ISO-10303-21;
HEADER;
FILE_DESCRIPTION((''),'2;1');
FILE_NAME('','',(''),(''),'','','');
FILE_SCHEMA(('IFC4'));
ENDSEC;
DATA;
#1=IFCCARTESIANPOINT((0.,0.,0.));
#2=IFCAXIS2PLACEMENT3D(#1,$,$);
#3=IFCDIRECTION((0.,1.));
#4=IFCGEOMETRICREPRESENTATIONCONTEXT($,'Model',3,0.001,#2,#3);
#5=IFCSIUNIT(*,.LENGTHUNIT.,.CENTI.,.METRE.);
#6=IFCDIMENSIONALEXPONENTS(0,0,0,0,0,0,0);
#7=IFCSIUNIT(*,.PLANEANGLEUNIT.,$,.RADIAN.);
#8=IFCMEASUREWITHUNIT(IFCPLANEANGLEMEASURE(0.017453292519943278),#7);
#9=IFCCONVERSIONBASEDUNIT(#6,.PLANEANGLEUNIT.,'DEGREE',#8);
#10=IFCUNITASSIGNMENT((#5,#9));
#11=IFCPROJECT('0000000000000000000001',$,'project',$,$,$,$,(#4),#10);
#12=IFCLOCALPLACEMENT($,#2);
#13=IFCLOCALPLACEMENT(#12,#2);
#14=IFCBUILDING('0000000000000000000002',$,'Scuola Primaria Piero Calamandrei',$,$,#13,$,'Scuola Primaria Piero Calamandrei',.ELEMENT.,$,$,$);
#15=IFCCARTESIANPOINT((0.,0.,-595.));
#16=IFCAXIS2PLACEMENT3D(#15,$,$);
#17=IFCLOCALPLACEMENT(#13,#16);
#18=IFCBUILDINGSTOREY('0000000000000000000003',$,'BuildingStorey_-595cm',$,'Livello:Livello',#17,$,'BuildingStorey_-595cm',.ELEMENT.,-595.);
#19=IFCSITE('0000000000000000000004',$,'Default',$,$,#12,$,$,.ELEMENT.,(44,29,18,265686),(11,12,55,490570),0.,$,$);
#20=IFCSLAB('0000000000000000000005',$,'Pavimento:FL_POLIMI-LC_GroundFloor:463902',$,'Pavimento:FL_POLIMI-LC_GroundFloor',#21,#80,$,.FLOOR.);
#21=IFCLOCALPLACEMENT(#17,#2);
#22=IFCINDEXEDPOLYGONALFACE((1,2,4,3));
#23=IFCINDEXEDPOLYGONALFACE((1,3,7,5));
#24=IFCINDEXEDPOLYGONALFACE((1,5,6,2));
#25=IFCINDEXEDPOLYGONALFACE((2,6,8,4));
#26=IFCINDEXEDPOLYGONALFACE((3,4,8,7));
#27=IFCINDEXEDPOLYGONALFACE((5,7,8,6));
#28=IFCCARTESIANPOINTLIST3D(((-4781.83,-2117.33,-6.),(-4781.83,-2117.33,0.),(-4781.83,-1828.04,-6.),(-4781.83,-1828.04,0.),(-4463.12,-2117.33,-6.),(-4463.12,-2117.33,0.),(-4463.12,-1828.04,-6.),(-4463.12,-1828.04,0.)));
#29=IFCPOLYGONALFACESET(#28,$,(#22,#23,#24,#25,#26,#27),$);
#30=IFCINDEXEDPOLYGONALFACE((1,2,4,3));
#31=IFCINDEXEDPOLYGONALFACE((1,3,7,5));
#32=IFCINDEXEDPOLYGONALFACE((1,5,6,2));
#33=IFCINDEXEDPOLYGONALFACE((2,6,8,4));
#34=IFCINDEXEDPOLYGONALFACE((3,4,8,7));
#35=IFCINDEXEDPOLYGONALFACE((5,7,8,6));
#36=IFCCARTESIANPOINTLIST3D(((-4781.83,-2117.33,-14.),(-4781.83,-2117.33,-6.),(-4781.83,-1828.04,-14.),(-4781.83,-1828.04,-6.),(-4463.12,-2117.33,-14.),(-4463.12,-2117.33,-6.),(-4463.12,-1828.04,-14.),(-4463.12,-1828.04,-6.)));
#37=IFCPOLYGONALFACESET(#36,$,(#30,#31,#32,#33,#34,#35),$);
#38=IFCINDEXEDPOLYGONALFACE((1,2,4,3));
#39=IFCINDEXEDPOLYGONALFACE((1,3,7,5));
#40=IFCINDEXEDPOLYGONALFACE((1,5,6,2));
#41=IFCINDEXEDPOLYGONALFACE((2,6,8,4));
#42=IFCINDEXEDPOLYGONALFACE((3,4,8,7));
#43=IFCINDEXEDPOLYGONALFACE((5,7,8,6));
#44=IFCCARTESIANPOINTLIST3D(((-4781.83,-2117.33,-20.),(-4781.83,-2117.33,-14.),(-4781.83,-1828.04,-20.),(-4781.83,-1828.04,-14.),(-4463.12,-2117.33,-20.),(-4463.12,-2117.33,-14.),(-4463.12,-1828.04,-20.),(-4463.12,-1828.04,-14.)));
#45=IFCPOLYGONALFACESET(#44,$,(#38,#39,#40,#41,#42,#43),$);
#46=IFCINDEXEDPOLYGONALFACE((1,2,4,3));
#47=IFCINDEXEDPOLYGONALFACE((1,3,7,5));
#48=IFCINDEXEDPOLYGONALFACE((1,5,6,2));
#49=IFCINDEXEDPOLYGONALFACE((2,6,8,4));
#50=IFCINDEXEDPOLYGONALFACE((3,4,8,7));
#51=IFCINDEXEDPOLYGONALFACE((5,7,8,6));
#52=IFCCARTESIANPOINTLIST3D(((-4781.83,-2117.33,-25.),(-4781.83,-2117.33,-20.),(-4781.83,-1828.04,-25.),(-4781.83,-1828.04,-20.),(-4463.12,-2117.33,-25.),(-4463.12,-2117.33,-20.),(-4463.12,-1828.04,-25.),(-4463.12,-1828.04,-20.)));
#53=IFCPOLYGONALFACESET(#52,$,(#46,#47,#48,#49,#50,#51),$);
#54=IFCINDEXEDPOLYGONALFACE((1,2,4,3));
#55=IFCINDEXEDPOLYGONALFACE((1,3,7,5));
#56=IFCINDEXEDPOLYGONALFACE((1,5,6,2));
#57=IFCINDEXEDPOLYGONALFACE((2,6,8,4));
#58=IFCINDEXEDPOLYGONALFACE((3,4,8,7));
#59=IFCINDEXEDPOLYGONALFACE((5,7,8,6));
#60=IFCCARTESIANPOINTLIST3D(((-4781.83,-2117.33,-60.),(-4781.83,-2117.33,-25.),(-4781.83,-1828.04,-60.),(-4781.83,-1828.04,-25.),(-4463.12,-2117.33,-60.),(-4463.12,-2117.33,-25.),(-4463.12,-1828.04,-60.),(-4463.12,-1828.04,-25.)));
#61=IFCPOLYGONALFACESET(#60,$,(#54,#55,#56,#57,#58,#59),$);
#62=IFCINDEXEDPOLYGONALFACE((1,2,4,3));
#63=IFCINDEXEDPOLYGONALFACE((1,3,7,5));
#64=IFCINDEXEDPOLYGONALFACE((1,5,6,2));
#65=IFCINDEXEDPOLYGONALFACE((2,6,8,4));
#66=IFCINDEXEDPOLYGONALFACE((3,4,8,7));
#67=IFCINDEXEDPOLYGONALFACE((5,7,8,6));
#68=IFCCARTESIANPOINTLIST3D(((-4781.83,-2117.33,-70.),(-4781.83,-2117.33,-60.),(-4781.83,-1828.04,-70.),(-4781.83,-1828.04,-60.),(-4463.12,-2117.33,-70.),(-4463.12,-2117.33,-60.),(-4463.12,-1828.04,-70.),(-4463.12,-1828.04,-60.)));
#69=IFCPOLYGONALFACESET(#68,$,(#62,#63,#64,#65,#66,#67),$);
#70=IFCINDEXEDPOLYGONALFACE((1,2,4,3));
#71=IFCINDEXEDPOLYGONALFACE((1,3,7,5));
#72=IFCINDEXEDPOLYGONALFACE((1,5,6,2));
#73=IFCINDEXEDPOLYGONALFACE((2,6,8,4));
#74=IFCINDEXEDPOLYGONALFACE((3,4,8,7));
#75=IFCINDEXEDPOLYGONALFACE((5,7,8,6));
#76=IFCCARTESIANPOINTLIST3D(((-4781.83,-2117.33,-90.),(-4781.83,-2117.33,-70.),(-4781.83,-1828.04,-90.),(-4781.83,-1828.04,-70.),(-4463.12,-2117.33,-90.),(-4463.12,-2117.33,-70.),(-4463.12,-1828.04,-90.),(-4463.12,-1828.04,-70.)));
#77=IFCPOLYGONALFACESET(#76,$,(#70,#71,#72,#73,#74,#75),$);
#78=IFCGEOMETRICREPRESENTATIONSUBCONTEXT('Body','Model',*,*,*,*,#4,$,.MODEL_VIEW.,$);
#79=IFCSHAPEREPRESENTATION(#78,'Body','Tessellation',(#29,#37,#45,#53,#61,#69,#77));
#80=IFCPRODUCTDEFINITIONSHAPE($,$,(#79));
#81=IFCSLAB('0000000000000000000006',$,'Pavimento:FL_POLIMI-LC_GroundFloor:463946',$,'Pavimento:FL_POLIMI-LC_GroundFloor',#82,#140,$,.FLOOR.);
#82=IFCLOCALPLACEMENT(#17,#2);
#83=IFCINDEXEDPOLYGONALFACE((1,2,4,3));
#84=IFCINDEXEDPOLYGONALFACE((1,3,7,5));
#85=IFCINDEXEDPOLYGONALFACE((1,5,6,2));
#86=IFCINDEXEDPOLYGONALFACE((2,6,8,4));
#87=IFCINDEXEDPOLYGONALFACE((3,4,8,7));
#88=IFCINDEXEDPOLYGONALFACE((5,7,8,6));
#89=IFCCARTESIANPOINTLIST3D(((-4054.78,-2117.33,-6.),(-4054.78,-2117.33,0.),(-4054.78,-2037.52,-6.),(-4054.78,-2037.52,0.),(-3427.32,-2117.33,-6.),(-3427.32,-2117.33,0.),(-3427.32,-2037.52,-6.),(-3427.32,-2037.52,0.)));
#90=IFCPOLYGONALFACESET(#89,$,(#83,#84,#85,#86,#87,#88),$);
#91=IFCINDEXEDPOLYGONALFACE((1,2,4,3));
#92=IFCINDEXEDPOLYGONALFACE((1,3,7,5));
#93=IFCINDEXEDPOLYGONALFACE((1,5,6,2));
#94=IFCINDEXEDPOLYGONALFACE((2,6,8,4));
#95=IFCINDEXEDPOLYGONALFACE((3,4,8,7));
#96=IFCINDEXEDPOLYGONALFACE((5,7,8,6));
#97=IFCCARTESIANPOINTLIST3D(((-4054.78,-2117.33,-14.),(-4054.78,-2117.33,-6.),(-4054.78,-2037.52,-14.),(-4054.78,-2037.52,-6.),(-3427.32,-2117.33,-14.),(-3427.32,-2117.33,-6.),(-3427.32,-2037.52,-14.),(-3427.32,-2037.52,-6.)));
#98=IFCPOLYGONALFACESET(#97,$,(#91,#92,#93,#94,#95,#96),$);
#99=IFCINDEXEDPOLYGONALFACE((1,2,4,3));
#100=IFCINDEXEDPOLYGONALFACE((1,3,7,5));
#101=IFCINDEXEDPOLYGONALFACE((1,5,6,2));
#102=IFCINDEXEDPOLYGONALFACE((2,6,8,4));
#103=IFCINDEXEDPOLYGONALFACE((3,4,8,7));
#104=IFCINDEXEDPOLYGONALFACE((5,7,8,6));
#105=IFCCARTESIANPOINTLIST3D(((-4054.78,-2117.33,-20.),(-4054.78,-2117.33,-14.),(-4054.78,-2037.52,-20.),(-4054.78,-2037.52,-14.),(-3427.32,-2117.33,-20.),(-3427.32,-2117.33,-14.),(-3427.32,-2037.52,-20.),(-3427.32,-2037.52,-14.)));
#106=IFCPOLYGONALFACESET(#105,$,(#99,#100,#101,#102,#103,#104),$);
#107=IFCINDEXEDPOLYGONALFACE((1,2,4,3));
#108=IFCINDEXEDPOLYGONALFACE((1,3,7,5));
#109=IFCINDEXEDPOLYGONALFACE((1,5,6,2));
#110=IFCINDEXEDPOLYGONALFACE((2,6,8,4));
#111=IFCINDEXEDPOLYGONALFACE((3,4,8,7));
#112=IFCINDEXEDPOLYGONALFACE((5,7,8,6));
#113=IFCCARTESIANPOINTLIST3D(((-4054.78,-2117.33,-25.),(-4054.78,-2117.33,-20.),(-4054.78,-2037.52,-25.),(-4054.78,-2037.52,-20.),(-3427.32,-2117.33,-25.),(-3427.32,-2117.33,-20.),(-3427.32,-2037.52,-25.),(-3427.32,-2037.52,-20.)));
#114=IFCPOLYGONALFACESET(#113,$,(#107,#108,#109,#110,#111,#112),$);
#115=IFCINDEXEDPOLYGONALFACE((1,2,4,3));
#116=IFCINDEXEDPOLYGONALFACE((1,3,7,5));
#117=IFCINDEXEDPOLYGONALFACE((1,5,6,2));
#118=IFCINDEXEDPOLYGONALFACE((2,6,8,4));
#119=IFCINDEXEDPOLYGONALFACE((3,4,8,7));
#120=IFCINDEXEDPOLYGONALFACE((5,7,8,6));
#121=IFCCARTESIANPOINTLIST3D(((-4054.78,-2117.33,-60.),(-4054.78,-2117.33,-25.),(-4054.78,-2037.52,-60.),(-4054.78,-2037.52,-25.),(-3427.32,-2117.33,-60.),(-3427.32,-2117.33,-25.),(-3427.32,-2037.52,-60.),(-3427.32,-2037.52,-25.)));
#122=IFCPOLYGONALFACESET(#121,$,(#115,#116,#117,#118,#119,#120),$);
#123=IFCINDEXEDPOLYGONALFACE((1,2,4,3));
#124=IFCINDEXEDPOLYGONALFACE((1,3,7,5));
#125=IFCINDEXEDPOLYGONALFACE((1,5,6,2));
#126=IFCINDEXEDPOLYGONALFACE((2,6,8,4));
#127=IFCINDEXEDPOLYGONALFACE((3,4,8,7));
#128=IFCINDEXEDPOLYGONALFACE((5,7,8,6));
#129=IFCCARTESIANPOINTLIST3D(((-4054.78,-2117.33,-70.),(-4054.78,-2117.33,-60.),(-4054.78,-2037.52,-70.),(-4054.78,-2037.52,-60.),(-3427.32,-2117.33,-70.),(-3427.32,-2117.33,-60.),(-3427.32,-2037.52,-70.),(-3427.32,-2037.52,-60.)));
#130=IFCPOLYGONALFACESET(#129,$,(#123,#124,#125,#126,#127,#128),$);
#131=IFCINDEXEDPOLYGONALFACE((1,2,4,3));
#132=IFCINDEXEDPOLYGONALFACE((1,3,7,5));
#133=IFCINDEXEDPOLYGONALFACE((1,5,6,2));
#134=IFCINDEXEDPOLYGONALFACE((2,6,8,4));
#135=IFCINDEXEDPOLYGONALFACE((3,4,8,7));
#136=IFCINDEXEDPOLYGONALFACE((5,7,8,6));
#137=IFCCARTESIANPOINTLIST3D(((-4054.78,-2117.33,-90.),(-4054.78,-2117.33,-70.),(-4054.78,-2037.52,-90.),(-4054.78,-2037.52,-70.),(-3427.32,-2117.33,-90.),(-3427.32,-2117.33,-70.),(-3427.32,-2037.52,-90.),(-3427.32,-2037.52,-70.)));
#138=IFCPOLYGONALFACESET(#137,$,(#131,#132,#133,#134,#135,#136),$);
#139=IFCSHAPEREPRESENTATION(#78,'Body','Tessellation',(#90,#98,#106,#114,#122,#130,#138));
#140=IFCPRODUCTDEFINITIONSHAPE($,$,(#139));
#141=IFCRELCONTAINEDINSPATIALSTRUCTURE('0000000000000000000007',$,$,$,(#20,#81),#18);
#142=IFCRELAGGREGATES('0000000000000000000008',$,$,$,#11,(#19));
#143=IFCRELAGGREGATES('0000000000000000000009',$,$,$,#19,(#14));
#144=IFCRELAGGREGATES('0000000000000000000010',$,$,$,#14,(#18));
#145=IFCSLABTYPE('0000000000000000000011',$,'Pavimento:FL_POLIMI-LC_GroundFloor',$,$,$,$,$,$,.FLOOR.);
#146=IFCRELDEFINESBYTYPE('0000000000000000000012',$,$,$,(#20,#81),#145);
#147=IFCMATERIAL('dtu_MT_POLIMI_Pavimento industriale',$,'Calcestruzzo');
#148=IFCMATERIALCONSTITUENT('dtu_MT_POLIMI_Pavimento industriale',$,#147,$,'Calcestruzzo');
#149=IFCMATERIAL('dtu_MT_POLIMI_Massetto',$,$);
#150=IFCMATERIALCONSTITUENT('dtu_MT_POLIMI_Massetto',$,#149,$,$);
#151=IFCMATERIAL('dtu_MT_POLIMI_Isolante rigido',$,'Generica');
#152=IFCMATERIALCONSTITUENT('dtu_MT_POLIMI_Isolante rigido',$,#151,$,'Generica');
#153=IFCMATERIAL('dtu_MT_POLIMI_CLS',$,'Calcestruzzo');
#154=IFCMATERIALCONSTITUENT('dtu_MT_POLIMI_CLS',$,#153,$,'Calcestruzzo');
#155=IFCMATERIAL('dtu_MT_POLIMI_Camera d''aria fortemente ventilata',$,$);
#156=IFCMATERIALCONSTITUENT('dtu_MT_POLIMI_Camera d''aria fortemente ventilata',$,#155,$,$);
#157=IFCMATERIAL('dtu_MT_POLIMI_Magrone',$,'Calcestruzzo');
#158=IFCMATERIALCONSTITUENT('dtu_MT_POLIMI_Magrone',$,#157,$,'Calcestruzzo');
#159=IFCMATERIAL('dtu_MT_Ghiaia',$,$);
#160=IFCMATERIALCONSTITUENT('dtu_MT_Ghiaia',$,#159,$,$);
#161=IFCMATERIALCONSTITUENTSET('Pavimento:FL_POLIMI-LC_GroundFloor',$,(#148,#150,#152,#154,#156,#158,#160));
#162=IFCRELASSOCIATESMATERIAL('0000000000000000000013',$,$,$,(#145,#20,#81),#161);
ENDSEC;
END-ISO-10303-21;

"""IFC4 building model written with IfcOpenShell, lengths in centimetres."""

from ifc_helpers import new_model, entity, si_unit, converted_unit, direction, frame, origin, place, context, subcontext, project, spatial, indexed_curve, outline, extrude, material, constituent, constituent_set, type_object, element, save


model = new_model("IFC4")

# Units and contexts
model_context = context("Model", 3, precision=0.001, world=origin(), true_north=direction((0.0, 1.0)))
body_context = subcontext(model_context, "Body", "Model", "MODEL_VIEW")
ifc_project = project(units=[si_unit("LENGTHUNIT", "METRE", prefix="CENTI"), converted_unit("PLANEANGLEUNIT", "DEGREE", entity("IfcPlaneAngleMeasure", 0.017453292519943278), si_unit("PLANEANGLEUNIT", "RADIAN"), dimensions=[0, 0, 0, 0, 0, 0, 0])], contexts=[model_context])

# Site, building, storey
site_placement = place(None, origin())
site = spatial("IfcSite", under=ifc_project, at=site_placement, Name="Default", CompositionType="ELEMENT", RefLatitude=(44, 29, 18, 265686), RefLongitude=(11, 12, 55, 490570), RefElevation=0.0)
building_placement = place(site_placement, origin())
building = spatial("IfcBuilding", under=site, at=building_placement, Name="Scuola Primaria Piero Calamandrei", LongName="Scuola Primaria Piero Calamandrei", CompositionType="ELEMENT")
storey_placement = place(building_placement, frame((0.0, 0.0, -595.0)))
storey = spatial("IfcBuildingStorey", under=building, at=storey_placement, Name="BuildingStorey_-595cm", ObjectType="Livello:Livello", LongName="BuildingStorey_-595cm", CompositionType="ELEMENT", Elevation=-595.0)

# Slabs
ifc_material_1 = material(Name="dtu_MT_POLIMI_Pavimento industriale", Category="Calcestruzzo")
ifc_constituent_1 = constituent(ifc_material_1, Name="dtu_MT_POLIMI_Pavimento industriale", Category="Calcestruzzo")
ifc_material_2 = material(Name="dtu_MT_POLIMI_Massetto")
ifc_constituent_2 = constituent(ifc_material_2, Name="dtu_MT_POLIMI_Massetto")
ifc_material_3 = material(Name="dtu_MT_POLIMI_Isolante rigido", Category="Generica")
ifc_constituent_3 = constituent(ifc_material_3, Name="dtu_MT_POLIMI_Isolante rigido", Category="Generica")
ifc_material_4 = material(Name="dtu_MT_POLIMI_CLS", Category="Calcestruzzo")
ifc_constituent_4 = constituent(ifc_material_4, Name="dtu_MT_POLIMI_CLS", Category="Calcestruzzo")
ifc_material_5 = material(Name="dtu_MT_POLIMI_Camera d'aria fortemente ventilata")
ifc_constituent_5 = constituent(ifc_material_5, Name="dtu_MT_POLIMI_Camera d'aria fortemente ventilata")
ifc_material_6 = material(Name="dtu_MT_POLIMI_Magrone", Category="Calcestruzzo")
ifc_constituent_6 = constituent(ifc_material_6, Name="dtu_MT_POLIMI_Magrone", Category="Calcestruzzo")
ifc_material_7 = material(Name="dtu_MT_Ghiaia")
ifc_constituent_7 = constituent(ifc_material_7, Name="dtu_MT_Ghiaia")
ifc_constituent_set_1 = constituent_set(constituents=[ifc_constituent_1, ifc_constituent_2, ifc_constituent_3, ifc_constituent_4, ifc_constituent_5, ifc_constituent_6, ifc_constituent_7], Name="Pavimento:FL_POLIMI-LC_GroundFloor")
slab_type = type_object("IfcSlabType", Name="Pavimento:FL_POLIMI-LC_GroundFloor", PredefinedType="FLOOR", material=ifc_constituent_set_1)
slab_1_placement = place(storey_placement, origin())
element("IfcSlab", 1, at=slab_1_placement, inside=storey, type_object=slab_type, material=ifc_constituent_set_1, Name="Pavimento:FL_POLIMI-LC_GroundFloor:463902", ObjectType="Pavimento:FL_POLIMI-LC_GroundFloor", PredefinedType="FLOOR", context=body_context, shape_type="SweptSolid", body=[
    extrude(outline(indexed_curve([(-159.35, -144.65), (159.35, -144.65), (159.35, 144.65), (-159.35, 144.65), (-159.35, -144.65)], self_intersect=False)), frame((-4622.48, -1972.68, -6.0), z_axis=(0.0, 0.0, 1.0), x_axis=(-1.0, 0.0, 0.0)), (0.0, 0.0, 1.0), 6.0),
    extrude(outline(indexed_curve([(-159.35, -144.65), (159.35, -144.65), (159.35, 144.65), (-159.35, 144.65), (-159.35, -144.65)], self_intersect=False)), frame((-4622.48, -1972.68, -14.0), z_axis=(0.0, 0.0, 1.0), x_axis=(-1.0, 0.0, 0.0)), (0.0, 0.0, 1.0), 8.0),
    extrude(outline(indexed_curve([(-159.35, -144.65), (159.35, -144.65), (159.35, 144.65), (-159.35, 144.65), (-159.35, -144.65)], self_intersect=False)), frame((-4622.48, -1972.68, -20.0), z_axis=(0.0, 0.0, 1.0), x_axis=(-1.0, 0.0, 0.0)), (0.0, 0.0, 1.0), 6.0),
    extrude(outline(indexed_curve([(-159.35, -144.65), (159.35, -144.65), (159.35, 144.65), (-159.35, 144.65), (-159.35, -144.65)], self_intersect=False)), frame((-4622.48, -1972.68, -25.0), z_axis=(0.0, 0.0, 1.0), x_axis=(-1.0, 0.0, 0.0)), (0.0, 0.0, 1.0), 5.0),
    extrude(outline(indexed_curve([(-159.35, -144.65), (159.35, -144.65), (159.35, 144.65), (-159.35, 144.65), (-159.35, -144.65)], self_intersect=False)), frame((-4622.48, -1972.68, -60.0), z_axis=(0.0, 0.0, 1.0), x_axis=(-1.0, 0.0, 0.0)), (0.0, 0.0, 1.0), 35.0),
    extrude(outline(indexed_curve([(-159.35, -144.65), (159.35, -144.65), (159.35, 144.65), (-159.35, 144.65), (-159.35, -144.65)], self_intersect=False)), frame((-4622.48, -1972.68, -70.0), z_axis=(0.0, 0.0, 1.0), x_axis=(-1.0, 0.0, 0.0)), (0.0, 0.0, 1.0), 10.0),
    extrude(outline(indexed_curve([(-159.35, -144.65), (159.35, -144.65), (159.35, 144.65), (-159.35, 144.65), (-159.35, -144.65)], self_intersect=False)), frame((-4622.48, -1972.68, -90.0), z_axis=(0.0, 0.0, 1.0), x_axis=(-1.0, 0.0, 0.0)), (0.0, 0.0, 1.0), 20.0),
])
slab_2_placement = place(storey_placement, origin())
element("IfcSlab", 2, at=slab_2_placement, inside=storey, type_object=slab_type, material=ifc_constituent_set_1, Name="Pavimento:FL_POLIMI-LC_GroundFloor:463946", ObjectType="Pavimento:FL_POLIMI-LC_GroundFloor", PredefinedType="FLOOR", context=body_context, shape_type="SweptSolid", body=[
    extrude(outline(indexed_curve([(-39.9, -313.73), (39.9, -313.73), (39.9, 313.73), (-39.9, 313.73), (-39.9, -313.73)], self_intersect=False)), frame((-3741.05, -2077.42, -6.0), z_axis=(0.0, 0.0, 1.0), x_axis=(0.0, -1.0, 0.0)), (0.0, 0.0, 1.0), 6.0),
    extrude(outline(indexed_curve([(-39.9, -313.73), (39.9, -313.73), (39.9, 313.73), (-39.9, 313.73), (-39.9, -313.73)], self_intersect=False)), frame((-3741.05, -2077.42, -14.0), z_axis=(0.0, 0.0, 1.0), x_axis=(0.0, -1.0, 0.0)), (0.0, 0.0, 1.0), 8.0),
    extrude(outline(indexed_curve([(-39.9, -313.73), (39.9, -313.73), (39.9, 313.73), (-39.9, 313.73), (-39.9, -313.73)], self_intersect=False)), frame((-3741.05, -2077.42, -20.0), z_axis=(0.0, 0.0, 1.0), x_axis=(0.0, -1.0, 0.0)), (0.0, 0.0, 1.0), 6.0),
    extrude(outline(indexed_curve([(-39.9, -313.73), (39.9, -313.73), (39.9, 313.73), (-39.9, 313.73), (-39.9, -313.73)], self_intersect=False)), frame((-3741.05, -2077.42, -25.0), z_axis=(0.0, 0.0, 1.0), x_axis=(0.0, -1.0, 0.0)), (0.0, 0.0, 1.0), 5.0),
    extrude(outline(indexed_curve([(-39.9, -313.73), (39.9, -313.73), (39.9, 313.73), (-39.9, 313.73), (-39.9, -313.73)], self_intersect=False)), frame((-3741.05, -2077.42, -60.0), z_axis=(0.0, 0.0, 1.0), x_axis=(0.0, -1.0, 0.0)), (0.0, 0.0, 1.0), 35.0),
    extrude(outline(indexed_curve([(-39.9, -313.73), (39.9, -313.73), (39.9, 313.73), (-39.9, 313.73), (-39.9, -313.73)], self_intersect=False)), frame((-3741.05, -2077.42, -70.0), z_axis=(0.0, 0.0, 1.0), x_axis=(0.0, -1.0, 0.0)), (0.0, 0.0, 1.0), 10.0),
    extrude(outline(indexed_curve([(-39.9, -313.73), (39.9, -313.73), (39.9, 313.73), (-39.9, 313.73), (-39.9, -313.73)], self_intersect=False)), frame((-3741.05, -2077.42, -90.0), z_axis=(0.0, 0.0, 1.0), x_axis=(0.0, -1.0, 0.0)), (0.0, 0.0, 1.0), 20.0),
])

save(model, "model.ifc")
